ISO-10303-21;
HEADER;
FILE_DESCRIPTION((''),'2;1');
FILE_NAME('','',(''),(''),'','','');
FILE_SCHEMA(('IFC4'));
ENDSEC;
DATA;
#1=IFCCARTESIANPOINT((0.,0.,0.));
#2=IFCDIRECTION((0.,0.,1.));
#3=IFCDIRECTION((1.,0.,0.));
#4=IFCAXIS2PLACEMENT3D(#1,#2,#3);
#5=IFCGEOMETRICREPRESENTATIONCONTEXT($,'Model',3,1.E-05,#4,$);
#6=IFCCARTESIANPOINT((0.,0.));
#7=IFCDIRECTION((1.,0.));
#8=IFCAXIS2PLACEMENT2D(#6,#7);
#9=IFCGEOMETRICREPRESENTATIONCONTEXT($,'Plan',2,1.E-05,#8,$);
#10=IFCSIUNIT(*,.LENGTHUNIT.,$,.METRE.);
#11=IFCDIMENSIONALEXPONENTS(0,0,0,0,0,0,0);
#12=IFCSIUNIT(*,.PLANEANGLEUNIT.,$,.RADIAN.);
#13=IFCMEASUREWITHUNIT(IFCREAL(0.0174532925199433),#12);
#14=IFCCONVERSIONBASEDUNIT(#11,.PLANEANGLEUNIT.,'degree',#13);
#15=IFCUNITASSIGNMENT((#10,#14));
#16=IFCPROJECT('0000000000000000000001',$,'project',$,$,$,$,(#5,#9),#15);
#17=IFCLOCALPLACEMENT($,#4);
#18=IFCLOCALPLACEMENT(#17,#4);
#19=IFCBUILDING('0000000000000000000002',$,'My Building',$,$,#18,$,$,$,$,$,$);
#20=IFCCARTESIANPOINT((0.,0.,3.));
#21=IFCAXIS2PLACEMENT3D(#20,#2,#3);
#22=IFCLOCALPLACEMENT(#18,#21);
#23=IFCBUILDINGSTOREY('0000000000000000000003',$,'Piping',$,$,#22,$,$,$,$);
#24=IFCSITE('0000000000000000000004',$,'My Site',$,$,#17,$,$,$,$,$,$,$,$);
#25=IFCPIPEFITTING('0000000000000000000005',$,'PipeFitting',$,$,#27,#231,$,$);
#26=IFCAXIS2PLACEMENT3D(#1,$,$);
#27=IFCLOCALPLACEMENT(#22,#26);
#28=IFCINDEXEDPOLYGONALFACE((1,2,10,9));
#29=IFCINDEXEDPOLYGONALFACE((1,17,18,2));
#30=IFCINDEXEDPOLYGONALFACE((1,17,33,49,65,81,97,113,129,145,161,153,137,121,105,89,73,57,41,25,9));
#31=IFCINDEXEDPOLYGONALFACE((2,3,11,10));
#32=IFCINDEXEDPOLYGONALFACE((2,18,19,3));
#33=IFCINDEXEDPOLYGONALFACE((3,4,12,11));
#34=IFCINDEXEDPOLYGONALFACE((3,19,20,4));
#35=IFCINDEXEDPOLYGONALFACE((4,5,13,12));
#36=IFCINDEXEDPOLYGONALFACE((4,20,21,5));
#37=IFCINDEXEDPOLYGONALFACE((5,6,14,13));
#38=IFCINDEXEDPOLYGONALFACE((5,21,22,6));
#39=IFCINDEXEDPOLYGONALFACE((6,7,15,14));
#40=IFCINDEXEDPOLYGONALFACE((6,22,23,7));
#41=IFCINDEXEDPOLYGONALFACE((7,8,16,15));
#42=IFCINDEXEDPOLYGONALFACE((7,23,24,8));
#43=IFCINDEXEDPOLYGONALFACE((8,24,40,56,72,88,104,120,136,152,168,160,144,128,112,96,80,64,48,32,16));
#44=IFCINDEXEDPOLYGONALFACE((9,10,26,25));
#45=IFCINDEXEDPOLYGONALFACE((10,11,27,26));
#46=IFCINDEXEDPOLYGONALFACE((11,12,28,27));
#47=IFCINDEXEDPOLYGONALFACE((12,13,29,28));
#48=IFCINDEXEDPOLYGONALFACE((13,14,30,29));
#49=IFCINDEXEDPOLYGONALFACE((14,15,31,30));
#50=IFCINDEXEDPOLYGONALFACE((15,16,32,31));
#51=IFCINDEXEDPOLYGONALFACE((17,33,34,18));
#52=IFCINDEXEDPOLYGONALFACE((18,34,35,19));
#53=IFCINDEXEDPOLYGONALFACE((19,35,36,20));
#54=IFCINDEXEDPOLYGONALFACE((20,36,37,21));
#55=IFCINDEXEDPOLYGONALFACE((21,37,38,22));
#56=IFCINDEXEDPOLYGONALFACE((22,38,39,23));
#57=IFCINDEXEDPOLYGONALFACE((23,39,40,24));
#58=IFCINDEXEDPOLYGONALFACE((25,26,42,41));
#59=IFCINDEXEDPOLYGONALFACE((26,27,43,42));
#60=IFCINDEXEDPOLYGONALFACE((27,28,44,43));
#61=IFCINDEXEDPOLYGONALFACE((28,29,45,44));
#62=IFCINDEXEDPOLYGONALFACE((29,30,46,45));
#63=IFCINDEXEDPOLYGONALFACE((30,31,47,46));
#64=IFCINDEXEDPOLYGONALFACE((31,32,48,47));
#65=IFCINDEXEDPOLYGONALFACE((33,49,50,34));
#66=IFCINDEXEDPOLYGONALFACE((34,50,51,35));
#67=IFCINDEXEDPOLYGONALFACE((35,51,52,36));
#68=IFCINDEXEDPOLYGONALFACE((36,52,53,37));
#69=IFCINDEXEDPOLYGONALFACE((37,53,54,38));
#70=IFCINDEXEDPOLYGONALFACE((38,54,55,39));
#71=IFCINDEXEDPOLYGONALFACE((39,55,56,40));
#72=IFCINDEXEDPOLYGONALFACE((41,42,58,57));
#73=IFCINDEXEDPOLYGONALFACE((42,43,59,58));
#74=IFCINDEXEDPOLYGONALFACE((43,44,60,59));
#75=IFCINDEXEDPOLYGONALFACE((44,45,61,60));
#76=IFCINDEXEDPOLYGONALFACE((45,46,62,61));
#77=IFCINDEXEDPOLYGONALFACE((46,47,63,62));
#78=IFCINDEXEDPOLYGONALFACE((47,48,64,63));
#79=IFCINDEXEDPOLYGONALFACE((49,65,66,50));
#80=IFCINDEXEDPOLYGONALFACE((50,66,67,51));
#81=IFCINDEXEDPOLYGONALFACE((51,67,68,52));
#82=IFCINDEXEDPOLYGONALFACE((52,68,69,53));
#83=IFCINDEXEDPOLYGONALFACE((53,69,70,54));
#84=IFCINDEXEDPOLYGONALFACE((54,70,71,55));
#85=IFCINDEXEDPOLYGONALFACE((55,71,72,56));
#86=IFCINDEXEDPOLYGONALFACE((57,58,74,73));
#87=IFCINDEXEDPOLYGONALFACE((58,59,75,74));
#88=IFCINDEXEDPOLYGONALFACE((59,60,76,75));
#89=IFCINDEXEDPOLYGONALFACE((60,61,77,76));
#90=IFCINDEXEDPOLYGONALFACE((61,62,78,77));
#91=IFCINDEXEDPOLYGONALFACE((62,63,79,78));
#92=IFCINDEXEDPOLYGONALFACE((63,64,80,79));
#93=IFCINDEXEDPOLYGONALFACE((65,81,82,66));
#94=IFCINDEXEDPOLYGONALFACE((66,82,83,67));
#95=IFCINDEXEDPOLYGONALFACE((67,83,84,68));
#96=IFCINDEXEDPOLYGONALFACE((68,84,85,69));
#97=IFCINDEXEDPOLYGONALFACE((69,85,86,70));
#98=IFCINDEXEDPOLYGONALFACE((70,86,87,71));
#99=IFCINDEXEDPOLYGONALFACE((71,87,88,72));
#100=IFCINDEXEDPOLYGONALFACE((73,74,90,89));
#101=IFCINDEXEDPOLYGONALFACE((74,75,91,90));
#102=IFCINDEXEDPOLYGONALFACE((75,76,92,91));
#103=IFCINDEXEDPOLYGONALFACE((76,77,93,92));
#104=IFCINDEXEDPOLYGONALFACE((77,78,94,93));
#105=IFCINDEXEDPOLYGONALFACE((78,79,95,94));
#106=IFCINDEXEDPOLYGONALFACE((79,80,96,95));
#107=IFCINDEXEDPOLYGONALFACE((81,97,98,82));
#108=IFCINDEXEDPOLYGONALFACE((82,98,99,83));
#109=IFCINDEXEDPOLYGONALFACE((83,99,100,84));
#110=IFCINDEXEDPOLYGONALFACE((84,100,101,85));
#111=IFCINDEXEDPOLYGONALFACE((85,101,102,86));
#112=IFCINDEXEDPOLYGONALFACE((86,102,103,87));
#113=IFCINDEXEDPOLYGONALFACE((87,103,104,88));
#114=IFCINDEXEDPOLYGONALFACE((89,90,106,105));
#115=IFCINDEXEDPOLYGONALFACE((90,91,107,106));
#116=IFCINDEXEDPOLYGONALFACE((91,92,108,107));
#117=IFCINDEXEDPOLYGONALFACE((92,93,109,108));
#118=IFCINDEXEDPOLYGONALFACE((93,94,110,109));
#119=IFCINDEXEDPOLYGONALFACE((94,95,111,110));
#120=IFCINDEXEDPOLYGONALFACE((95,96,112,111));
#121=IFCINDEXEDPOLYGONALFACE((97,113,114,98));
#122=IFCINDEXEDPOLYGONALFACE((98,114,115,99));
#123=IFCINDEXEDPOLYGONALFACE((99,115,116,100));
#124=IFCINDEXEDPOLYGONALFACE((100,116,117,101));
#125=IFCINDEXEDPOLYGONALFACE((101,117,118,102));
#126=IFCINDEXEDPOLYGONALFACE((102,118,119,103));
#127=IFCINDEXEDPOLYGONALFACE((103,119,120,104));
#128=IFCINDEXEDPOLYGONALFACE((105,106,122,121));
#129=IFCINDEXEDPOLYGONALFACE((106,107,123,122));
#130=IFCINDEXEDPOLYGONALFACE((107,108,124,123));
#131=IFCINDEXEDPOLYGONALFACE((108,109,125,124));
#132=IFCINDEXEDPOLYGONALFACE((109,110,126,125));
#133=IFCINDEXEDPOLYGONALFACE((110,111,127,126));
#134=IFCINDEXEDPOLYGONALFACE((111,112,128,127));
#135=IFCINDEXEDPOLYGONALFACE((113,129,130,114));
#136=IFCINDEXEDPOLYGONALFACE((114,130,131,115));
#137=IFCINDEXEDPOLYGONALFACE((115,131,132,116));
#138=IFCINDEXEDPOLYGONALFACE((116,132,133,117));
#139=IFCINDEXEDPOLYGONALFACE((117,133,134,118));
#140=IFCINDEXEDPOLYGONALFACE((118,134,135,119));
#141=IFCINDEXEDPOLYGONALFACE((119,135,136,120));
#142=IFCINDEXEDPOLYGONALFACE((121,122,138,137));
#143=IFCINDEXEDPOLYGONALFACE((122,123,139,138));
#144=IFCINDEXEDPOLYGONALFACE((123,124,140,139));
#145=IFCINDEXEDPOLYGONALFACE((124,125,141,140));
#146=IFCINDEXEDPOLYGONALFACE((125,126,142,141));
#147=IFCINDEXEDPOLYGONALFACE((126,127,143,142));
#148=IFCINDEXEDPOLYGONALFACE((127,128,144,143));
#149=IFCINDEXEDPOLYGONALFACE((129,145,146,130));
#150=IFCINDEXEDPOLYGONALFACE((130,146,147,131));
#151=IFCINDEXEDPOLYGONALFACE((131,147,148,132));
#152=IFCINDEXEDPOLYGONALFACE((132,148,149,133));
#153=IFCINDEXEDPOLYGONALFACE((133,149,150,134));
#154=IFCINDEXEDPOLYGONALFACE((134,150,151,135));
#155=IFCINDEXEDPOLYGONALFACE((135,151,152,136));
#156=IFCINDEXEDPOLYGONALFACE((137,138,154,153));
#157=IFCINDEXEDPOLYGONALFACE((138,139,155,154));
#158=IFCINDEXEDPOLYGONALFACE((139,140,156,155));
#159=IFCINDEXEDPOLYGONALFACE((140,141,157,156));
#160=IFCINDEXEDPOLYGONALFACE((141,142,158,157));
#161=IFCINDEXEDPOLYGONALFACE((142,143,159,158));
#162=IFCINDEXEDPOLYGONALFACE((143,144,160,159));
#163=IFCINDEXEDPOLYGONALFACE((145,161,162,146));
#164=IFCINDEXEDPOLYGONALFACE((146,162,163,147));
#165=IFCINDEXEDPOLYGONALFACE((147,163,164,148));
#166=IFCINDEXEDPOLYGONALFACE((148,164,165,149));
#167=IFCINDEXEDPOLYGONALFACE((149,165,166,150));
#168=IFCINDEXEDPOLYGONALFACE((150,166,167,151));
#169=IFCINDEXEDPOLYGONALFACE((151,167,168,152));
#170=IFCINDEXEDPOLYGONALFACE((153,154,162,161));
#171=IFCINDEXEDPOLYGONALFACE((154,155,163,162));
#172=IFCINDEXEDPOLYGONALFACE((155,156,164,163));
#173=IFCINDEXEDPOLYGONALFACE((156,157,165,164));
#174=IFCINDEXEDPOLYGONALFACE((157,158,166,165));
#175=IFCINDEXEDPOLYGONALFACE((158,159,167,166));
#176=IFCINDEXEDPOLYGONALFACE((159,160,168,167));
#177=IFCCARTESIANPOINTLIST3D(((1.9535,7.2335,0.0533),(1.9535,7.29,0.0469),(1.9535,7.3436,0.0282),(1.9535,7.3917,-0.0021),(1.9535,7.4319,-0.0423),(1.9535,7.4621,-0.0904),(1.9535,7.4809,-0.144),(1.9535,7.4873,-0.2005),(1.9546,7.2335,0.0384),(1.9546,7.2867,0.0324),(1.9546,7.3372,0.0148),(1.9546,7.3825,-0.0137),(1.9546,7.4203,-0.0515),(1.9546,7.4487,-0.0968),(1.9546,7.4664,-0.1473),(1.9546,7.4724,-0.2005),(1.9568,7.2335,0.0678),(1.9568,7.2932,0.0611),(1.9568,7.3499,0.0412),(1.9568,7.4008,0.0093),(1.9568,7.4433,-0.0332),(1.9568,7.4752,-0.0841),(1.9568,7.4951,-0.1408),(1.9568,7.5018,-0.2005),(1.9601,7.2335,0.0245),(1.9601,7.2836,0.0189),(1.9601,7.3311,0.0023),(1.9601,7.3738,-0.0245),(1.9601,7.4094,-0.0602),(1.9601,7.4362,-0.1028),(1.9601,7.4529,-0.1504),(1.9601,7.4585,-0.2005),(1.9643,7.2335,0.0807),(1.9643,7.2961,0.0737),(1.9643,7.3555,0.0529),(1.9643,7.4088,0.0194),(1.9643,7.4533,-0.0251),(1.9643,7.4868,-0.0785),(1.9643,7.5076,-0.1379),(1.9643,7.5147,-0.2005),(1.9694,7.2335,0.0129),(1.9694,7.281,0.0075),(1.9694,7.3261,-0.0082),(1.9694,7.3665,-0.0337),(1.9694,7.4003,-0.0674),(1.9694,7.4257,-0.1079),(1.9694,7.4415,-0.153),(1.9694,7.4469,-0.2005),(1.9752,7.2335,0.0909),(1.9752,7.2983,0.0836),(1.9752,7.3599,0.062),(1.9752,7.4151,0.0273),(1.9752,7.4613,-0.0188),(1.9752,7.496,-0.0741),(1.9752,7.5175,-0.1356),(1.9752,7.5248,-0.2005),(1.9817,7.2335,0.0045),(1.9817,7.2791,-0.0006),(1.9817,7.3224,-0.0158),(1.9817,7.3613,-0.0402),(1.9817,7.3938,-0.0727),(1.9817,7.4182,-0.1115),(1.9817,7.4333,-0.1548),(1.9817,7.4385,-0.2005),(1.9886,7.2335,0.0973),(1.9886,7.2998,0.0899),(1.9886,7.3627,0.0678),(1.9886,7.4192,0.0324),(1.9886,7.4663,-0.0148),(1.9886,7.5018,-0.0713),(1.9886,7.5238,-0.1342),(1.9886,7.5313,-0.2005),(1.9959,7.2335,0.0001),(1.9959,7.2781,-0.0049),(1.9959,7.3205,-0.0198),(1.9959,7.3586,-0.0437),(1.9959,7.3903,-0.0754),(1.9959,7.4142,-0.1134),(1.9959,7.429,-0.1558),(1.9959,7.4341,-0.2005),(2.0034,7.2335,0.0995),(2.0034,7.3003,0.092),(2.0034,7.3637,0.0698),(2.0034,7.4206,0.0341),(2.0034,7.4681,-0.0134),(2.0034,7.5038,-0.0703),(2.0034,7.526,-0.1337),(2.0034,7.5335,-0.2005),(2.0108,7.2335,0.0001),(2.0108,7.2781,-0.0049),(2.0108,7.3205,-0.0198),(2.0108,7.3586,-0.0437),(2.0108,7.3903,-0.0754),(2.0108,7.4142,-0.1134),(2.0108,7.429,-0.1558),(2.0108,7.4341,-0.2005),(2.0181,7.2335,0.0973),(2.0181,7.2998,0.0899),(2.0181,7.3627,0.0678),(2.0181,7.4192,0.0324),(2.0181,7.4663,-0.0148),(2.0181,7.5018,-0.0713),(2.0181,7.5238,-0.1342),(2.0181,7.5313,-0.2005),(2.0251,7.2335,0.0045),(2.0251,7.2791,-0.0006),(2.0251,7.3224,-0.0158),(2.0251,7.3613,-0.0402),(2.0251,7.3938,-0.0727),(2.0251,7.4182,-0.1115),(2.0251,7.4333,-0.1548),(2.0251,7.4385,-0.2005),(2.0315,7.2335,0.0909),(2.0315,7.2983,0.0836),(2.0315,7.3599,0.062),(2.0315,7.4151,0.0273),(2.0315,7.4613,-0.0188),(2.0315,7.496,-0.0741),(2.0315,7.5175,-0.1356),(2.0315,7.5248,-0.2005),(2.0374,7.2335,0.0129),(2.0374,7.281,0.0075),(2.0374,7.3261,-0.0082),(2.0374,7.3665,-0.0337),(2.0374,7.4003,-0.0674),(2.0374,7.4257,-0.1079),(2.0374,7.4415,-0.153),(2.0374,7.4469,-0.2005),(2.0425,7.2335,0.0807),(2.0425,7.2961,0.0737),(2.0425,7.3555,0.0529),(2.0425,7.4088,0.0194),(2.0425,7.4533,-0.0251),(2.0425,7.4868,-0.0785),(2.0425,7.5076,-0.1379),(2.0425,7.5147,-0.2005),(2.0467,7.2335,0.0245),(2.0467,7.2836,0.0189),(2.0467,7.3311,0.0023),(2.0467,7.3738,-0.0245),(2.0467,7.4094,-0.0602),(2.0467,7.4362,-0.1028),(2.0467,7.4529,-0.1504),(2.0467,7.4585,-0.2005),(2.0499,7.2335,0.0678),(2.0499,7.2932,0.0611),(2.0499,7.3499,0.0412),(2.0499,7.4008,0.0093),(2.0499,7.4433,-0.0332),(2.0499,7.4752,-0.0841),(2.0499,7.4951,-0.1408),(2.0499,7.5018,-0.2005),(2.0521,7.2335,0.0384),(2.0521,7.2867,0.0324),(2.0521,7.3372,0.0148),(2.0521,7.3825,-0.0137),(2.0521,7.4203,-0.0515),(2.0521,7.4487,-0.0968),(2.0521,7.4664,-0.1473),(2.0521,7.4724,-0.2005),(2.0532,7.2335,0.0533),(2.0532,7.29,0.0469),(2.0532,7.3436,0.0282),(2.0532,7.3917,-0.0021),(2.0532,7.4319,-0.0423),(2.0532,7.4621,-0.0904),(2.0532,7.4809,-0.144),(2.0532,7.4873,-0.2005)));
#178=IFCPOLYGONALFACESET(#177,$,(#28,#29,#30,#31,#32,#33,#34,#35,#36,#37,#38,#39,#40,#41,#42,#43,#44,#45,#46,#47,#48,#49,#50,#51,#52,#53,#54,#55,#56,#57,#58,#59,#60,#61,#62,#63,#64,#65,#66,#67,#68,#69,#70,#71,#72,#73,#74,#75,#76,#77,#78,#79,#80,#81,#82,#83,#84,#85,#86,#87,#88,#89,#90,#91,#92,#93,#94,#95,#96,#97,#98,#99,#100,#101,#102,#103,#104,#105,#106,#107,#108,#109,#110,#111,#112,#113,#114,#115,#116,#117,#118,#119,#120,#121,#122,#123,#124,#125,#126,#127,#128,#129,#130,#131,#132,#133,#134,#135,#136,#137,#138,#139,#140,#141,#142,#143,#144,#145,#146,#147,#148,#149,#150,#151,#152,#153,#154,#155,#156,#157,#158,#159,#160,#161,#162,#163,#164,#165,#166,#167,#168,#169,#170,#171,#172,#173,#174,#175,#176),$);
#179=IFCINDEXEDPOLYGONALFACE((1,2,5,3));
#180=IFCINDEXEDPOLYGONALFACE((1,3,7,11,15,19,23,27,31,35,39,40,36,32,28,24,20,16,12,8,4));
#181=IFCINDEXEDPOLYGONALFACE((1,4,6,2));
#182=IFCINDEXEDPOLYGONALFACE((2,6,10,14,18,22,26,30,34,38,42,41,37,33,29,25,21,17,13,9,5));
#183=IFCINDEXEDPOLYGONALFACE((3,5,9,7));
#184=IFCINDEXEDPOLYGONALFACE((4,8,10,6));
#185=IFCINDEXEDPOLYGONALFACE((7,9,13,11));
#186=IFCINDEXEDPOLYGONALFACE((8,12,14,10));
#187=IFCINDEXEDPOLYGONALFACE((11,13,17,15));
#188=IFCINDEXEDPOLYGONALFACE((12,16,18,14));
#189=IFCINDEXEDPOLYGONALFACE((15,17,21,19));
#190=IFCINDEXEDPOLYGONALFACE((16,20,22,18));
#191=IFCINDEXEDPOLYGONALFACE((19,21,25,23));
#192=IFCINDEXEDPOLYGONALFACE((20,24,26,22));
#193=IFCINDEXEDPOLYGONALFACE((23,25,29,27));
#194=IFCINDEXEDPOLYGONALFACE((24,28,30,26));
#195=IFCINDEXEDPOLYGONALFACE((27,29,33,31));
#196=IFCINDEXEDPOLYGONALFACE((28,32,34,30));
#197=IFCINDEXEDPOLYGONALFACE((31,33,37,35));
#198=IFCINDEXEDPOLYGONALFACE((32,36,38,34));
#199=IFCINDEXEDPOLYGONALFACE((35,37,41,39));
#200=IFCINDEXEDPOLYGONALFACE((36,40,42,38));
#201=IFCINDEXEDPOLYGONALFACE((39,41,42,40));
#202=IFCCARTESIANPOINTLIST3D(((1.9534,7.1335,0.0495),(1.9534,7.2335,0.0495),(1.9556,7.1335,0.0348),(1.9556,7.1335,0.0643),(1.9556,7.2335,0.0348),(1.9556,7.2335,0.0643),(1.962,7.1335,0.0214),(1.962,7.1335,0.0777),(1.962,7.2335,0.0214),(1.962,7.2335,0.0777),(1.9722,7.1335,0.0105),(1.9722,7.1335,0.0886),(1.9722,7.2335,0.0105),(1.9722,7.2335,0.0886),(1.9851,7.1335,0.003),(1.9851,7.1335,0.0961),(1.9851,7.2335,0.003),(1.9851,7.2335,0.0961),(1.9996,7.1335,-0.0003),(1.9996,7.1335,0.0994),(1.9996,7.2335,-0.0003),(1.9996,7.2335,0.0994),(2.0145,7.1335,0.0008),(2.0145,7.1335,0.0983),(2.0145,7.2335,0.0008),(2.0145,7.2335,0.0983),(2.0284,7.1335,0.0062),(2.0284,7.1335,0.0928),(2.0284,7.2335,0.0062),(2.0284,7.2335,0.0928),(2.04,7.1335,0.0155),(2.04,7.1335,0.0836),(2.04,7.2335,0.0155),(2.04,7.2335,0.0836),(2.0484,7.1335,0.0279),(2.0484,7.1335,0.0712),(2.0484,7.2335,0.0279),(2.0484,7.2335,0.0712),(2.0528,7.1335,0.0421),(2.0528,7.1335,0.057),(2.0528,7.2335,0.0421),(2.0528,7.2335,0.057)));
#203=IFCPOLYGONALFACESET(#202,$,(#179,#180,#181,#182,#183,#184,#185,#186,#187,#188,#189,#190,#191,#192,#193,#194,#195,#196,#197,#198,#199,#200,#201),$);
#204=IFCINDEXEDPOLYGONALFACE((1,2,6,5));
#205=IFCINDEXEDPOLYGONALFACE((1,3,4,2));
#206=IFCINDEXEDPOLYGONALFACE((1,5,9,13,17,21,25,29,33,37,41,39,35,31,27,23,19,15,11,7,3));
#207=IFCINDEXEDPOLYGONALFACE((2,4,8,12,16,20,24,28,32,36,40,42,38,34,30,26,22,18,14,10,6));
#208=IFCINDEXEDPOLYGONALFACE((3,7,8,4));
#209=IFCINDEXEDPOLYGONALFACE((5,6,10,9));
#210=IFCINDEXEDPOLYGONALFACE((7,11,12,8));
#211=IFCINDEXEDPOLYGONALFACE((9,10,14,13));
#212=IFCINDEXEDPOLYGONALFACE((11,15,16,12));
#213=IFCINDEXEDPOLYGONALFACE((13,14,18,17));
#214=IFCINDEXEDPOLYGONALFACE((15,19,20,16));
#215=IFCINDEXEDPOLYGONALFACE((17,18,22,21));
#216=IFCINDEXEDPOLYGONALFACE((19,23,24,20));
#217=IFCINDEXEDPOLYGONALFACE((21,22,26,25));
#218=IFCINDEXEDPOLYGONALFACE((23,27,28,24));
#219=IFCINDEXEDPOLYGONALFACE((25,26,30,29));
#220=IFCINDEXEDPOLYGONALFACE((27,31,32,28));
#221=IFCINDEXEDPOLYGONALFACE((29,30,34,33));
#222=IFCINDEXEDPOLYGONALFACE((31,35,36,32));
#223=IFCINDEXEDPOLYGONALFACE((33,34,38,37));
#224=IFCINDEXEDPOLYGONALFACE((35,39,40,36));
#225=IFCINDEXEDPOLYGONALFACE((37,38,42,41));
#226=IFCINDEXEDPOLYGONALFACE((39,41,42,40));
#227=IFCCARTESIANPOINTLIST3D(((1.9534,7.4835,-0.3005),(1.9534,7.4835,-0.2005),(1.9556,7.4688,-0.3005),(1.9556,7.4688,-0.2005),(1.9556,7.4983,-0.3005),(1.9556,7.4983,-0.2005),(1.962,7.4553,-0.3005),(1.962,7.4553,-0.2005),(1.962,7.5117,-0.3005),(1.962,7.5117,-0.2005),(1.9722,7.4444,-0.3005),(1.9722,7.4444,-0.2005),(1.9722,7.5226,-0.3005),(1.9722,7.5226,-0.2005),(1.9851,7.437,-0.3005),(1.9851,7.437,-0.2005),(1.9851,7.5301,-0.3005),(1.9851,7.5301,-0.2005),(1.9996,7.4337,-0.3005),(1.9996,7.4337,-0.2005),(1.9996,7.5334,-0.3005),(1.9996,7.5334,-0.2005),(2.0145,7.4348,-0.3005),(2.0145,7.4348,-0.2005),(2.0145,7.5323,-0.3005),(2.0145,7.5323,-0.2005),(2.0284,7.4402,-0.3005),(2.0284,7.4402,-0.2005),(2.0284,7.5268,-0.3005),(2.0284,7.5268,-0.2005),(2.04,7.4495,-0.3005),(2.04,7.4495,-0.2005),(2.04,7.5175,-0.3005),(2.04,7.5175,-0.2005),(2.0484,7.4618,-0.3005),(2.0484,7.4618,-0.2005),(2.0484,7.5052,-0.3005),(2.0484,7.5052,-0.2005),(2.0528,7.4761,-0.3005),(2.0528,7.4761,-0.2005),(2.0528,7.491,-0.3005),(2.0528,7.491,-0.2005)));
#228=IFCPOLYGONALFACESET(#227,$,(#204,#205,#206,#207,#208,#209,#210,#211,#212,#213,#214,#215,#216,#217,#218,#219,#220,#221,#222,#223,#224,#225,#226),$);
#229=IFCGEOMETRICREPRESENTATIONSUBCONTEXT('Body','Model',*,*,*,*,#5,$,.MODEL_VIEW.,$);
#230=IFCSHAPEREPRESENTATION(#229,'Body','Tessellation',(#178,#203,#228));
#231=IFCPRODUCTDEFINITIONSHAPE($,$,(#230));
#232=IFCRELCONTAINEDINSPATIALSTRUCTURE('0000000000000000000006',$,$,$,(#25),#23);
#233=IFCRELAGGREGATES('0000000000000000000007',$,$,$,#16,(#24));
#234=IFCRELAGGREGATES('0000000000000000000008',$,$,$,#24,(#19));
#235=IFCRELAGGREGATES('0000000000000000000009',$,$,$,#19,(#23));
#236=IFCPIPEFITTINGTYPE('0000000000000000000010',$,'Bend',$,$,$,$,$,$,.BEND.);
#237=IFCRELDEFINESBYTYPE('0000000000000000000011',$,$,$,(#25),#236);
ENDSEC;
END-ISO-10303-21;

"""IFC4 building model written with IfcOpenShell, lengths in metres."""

from ifc_helpers import new_model, entity, si_unit, converted_unit, frame, origin_with_axes, origin_2d_with_axis, place, context, subcontext, project, spatial, circle, extrude, source, transform, mapped, type_object, type_shapes, element, save


model = new_model("IFC4")

# Units and contexts
model_context = context("Model", 3, precision=1e-05, world=origin_with_axes())
plan_context = context("Plan", 2, precision=1e-05, world=origin_2d_with_axis())
body_context = subcontext(model_context, "Body", "Model", "MODEL_VIEW")
ifc_project = project(units=[si_unit("LENGTHUNIT", "METRE"), converted_unit("PLANEANGLEUNIT", "degree", entity("IfcReal", 0.0174532925199433), si_unit("PLANEANGLEUNIT", "RADIAN"), dimensions=[0, 0, 0, 0, 0, 0, 0])], contexts=[model_context, plan_context])

# Site, building, storey
site_placement = place(None, origin_with_axes())
site = spatial("IfcSite", under=ifc_project, at=site_placement, Name="My Site")
building_placement = place(site_placement, origin_with_axes())
building = spatial("IfcBuilding", under=site, at=building_placement, Name="My Building")
storey_placement = place(building_placement, frame((0.0, 0.0, 3.0), z_axis=(0.0, 0.0, 1.0), x_axis=(1.0, 0.0, 0.0)))
storey = spatial("IfcBuildingStorey", under=building, at=storey_placement, Name="Piping")

# Pipe fitting
pipe_fitting_type = type_object("IfcPipeFittingType", Name="Bend", PredefinedType="BEND")
shared_shape = source(origin_with_axes(), body_context, "Body", "SolidModel", [
    entity("IfcSweptDiskSolid", entity("IfcIndexedPolyCurve", entity("IfcCartesianPointList3D", [[0.0, 0.0, 0.1], [0.0, -0.0732, 0.2768], [0.0, -0.25, 0.35]]), [entity("IfcArcIndex", [1, 2, 3])]), 0.05),
    extrude(circle(Radius=0.05), origin_with_axes(), (0.0, 0.0, 1.0), 0.1),
    extrude(circle(Radius=0.05), frame((0.0, -0.25, 0.35), z_axis=(0.0, -1.0, 0.0), x_axis=(1.0, 0.0, 0.0)), (0.0, 0.0, 1.0), 0.1),
])
type_shapes(pipe_fitting_type, [shared_shape])
for number, where, z_axis, x_axis, name in (
    (1, (2.0034, 7.1335, 0.0495), (0.0, 1.0, 0.0), (-1.0, 0.0, 0.0), "PipeFitting"),
):
    element("IfcPipeFitting", number, at=place(storey_placement, frame(where, z_axis=z_axis, x_axis=x_axis)), inside=storey, type_object=pipe_fitting_type, Name=name, context=body_context, shape_type="MappedRepresentation", body=[
        mapped(shared_shape, transform((0.0, 0.0, 0.0), x_axis=(1.0, 0.0, 0.0), y_axis=(0.0, 1.0, 0.0), z_axis=(0.0, 0.0, 1.0), scale=1.0)),
    ])

save(model, "model.ifc")
